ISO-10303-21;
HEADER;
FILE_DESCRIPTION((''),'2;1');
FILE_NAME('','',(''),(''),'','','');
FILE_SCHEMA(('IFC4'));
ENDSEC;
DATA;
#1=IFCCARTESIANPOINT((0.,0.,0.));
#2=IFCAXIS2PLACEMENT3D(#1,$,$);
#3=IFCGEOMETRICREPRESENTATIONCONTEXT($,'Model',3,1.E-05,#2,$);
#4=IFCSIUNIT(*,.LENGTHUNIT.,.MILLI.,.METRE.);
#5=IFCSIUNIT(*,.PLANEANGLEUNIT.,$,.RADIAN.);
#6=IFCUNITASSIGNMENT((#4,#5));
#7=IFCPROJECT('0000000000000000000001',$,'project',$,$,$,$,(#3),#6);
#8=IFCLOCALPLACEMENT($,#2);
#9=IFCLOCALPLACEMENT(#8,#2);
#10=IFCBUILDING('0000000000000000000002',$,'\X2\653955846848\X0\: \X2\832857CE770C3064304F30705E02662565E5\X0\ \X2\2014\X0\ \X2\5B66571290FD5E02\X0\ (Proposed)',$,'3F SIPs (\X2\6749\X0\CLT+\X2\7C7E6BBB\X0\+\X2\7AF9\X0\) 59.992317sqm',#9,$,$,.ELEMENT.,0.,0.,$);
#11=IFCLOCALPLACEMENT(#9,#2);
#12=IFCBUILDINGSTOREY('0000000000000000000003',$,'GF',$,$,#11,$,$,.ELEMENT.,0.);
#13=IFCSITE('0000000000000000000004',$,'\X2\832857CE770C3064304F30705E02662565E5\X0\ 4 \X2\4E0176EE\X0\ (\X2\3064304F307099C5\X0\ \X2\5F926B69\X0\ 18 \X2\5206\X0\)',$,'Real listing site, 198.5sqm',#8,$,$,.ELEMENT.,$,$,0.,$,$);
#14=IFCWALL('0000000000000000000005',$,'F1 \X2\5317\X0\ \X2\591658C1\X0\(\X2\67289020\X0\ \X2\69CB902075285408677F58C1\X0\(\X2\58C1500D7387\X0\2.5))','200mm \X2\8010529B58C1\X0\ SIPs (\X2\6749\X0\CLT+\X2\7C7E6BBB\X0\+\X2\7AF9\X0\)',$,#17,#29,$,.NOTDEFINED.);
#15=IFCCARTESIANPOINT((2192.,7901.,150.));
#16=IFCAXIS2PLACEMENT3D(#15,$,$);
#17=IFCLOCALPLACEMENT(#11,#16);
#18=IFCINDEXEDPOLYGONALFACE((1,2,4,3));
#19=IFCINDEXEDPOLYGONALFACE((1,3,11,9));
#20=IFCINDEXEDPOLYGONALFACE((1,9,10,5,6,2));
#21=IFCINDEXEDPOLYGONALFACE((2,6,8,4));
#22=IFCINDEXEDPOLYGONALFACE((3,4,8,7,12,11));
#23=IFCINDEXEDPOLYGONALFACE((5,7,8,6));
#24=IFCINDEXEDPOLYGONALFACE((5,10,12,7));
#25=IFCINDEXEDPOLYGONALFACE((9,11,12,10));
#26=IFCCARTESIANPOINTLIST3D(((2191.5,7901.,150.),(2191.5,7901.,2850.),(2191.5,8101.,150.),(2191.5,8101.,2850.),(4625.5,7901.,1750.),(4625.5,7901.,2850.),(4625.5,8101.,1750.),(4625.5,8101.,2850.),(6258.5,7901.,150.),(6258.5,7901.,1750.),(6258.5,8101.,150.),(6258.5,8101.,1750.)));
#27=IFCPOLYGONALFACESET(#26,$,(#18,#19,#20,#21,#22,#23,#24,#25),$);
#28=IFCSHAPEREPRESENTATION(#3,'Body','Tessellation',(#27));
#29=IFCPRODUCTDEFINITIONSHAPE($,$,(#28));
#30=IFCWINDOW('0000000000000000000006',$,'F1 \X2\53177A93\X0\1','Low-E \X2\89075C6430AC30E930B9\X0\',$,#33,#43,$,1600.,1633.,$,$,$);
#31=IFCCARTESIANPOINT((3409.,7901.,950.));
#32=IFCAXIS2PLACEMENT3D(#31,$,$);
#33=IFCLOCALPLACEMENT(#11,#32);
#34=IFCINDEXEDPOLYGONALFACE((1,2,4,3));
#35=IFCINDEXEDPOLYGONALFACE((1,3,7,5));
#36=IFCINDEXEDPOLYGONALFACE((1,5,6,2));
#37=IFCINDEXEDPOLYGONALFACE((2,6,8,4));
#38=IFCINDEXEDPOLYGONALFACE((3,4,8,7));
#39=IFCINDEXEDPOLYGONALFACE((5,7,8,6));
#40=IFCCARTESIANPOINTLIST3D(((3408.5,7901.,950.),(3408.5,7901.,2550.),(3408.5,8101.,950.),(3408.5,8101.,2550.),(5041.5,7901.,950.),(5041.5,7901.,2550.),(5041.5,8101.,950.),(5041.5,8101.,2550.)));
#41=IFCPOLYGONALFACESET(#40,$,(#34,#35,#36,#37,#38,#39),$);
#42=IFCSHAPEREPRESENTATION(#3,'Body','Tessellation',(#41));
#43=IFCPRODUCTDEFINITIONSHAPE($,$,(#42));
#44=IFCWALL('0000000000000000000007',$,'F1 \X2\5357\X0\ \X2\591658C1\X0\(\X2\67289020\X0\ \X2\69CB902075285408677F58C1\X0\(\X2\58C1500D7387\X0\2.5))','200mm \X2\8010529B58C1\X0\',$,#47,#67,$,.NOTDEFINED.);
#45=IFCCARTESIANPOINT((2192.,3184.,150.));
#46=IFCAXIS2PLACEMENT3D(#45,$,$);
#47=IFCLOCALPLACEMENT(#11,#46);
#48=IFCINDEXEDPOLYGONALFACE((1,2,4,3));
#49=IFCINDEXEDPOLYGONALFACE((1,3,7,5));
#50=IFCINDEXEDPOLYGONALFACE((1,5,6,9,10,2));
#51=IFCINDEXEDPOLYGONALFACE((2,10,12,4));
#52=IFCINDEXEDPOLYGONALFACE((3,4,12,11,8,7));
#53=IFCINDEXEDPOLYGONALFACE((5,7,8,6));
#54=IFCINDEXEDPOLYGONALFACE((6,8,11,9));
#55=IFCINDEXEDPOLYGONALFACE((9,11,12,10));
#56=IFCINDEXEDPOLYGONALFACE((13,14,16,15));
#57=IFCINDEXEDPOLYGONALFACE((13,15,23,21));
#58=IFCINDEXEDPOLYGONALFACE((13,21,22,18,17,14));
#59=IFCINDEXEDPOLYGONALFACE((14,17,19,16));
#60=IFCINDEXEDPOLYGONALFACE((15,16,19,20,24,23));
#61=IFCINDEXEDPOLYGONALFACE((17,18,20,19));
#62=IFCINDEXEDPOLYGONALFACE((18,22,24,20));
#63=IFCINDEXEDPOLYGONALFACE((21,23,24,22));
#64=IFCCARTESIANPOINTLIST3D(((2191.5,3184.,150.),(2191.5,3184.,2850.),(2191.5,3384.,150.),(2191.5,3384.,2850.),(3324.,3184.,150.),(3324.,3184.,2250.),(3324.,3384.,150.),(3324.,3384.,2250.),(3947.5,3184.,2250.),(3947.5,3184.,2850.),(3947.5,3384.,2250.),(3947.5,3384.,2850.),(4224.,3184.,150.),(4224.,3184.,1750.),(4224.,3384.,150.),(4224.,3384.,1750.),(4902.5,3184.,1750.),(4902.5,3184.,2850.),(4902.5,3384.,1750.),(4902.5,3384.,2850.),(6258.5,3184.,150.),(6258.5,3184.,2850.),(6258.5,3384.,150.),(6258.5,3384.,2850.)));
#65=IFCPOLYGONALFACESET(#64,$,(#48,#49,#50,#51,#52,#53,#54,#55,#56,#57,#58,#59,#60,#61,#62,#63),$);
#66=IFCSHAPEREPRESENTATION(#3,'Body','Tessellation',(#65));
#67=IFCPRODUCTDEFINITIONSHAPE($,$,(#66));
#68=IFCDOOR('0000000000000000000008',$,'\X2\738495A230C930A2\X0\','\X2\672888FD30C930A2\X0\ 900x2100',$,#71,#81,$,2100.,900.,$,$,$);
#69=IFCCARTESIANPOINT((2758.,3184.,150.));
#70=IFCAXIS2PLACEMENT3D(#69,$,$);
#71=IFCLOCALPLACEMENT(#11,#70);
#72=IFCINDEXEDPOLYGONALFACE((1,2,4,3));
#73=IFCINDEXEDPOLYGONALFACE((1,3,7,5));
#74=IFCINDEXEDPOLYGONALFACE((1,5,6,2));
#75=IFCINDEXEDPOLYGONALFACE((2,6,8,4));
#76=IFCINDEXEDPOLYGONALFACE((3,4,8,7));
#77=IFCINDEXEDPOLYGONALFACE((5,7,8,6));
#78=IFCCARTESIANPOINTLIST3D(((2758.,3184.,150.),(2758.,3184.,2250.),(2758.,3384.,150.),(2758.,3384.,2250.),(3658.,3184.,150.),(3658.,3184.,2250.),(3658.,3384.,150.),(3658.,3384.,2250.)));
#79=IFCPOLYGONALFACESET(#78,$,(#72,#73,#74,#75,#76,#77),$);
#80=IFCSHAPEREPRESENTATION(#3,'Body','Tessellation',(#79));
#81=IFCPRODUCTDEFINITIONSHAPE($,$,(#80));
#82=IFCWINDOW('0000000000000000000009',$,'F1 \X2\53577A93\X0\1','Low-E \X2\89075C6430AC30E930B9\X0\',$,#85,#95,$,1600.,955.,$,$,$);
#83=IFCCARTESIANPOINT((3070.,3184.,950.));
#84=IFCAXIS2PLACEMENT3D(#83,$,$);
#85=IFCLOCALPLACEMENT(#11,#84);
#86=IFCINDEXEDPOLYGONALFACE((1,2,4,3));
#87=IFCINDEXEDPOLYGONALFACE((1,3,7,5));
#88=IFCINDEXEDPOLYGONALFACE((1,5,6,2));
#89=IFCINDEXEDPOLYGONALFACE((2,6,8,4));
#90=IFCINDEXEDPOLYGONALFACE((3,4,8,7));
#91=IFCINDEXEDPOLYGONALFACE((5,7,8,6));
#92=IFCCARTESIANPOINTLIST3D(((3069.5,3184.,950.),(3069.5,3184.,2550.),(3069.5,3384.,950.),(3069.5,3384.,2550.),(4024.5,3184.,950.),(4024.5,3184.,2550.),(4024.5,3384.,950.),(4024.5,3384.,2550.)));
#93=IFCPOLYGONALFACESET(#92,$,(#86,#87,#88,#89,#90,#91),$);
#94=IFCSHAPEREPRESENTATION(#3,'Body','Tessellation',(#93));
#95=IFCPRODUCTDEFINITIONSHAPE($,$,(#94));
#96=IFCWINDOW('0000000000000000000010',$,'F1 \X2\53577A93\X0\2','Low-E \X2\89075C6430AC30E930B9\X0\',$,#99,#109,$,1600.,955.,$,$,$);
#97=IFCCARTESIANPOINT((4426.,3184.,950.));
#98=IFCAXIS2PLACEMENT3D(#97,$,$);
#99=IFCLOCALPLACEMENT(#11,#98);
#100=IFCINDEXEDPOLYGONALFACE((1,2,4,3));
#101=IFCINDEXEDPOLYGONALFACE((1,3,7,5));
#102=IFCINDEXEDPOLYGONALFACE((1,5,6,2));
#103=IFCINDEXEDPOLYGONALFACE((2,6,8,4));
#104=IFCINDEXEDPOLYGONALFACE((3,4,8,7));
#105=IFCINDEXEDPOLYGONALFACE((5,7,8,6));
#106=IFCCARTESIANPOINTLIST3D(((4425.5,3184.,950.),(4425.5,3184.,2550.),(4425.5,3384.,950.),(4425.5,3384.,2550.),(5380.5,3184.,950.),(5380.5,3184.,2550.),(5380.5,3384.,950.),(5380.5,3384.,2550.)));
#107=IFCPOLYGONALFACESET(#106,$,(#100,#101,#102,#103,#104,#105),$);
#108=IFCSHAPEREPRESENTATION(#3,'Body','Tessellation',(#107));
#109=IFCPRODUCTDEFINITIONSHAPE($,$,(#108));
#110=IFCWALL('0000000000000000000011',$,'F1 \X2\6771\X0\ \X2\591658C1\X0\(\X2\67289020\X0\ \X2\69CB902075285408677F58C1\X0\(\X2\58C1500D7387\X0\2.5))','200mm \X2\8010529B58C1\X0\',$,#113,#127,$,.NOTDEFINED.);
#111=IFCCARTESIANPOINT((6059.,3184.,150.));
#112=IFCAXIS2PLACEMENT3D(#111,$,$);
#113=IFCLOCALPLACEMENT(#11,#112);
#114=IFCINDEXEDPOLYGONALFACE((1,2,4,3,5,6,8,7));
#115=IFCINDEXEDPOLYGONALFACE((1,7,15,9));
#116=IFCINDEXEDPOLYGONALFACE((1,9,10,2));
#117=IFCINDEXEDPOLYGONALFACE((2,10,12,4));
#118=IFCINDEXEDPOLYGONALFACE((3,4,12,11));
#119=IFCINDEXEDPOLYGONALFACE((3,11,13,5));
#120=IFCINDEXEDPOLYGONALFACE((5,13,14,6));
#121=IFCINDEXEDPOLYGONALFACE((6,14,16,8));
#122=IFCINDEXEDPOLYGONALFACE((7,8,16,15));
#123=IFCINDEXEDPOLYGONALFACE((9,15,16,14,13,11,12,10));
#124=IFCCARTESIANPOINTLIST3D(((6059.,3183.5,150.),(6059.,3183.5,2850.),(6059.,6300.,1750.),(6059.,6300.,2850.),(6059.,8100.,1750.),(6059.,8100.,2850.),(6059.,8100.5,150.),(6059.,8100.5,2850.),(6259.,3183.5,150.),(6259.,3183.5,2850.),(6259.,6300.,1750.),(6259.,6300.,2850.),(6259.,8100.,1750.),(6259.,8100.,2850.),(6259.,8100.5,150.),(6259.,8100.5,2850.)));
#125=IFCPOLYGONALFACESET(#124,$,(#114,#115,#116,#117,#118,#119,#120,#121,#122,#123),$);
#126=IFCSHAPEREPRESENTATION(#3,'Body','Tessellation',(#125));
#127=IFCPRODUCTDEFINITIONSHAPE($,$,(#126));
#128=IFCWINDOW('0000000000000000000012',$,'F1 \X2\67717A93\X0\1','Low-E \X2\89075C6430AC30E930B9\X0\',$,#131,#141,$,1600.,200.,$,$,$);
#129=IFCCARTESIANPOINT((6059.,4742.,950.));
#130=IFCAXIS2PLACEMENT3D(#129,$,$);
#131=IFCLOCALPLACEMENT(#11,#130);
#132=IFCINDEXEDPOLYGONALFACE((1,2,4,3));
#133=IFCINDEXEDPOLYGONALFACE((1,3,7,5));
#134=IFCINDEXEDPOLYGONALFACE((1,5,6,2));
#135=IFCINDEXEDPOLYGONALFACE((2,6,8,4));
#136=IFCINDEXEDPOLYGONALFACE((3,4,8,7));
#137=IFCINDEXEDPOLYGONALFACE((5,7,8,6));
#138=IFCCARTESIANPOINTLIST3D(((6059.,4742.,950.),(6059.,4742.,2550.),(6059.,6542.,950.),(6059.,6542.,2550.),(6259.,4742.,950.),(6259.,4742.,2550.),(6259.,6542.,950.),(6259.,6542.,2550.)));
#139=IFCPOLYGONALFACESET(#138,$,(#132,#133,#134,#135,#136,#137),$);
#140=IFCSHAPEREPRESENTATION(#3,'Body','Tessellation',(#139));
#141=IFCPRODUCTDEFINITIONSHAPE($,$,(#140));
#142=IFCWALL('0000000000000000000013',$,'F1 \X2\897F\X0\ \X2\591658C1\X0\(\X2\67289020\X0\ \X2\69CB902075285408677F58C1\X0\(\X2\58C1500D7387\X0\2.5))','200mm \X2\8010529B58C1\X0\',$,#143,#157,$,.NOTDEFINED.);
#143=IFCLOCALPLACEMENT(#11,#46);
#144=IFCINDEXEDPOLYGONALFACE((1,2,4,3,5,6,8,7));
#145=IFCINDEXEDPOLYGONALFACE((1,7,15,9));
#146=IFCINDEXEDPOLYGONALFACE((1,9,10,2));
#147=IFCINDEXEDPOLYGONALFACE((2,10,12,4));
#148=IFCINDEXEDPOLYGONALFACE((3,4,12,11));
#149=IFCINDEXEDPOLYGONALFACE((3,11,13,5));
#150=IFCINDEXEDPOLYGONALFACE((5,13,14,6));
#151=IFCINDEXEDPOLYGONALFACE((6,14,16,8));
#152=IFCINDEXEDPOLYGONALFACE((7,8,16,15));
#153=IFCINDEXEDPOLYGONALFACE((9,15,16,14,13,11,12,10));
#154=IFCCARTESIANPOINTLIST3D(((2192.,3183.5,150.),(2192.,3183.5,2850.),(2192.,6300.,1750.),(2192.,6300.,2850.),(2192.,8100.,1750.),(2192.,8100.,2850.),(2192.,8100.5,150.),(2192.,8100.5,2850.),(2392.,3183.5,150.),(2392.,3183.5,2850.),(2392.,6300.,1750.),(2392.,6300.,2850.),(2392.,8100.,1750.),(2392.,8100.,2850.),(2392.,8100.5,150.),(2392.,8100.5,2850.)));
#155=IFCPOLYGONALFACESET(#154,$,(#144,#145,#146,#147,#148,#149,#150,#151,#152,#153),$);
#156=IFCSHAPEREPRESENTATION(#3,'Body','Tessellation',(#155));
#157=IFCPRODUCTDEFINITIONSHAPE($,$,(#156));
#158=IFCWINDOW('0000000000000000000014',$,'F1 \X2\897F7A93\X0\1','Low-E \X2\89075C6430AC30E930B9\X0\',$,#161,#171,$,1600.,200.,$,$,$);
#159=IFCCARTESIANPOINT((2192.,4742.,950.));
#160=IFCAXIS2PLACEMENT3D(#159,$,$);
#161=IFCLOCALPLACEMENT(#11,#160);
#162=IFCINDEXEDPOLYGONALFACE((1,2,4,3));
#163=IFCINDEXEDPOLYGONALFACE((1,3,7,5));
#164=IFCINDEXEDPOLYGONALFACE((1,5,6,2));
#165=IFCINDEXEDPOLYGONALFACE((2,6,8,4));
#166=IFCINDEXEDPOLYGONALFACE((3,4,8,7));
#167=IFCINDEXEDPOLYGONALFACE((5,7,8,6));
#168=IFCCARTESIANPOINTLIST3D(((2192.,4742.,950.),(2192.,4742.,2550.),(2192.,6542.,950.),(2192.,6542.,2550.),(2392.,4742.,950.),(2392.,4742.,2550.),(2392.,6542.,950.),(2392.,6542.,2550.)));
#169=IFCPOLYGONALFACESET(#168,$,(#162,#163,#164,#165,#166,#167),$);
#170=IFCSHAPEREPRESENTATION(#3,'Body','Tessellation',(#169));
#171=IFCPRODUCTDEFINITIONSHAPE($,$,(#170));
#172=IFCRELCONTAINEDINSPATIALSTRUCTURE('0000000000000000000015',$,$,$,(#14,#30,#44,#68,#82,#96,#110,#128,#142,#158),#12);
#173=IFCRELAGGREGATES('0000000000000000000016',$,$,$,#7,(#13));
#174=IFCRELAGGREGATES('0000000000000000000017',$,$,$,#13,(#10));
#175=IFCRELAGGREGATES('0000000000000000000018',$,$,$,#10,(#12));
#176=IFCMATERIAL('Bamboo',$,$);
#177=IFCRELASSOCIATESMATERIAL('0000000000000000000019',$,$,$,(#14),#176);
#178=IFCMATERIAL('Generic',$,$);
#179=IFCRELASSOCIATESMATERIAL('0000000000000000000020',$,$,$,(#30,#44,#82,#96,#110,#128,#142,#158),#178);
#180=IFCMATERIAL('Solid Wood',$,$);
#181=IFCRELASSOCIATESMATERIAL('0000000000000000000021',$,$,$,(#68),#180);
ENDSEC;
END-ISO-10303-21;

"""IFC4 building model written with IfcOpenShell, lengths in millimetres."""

from ifc_helpers import new_model, si_unit, frame, frame_2d, origin, place, context, project, spatial, rectangle, extrude, material, element, fill, save


model = new_model("IFC4")

# Units and contexts
model_context = context("Model", 3, precision=1e-05, world=origin())
ifc_project = project(units=[si_unit("LENGTHUNIT", "METRE", prefix="MILLI"), si_unit("PLANEANGLEUNIT", "RADIAN")], contexts=[model_context])

# Site, building, storey
site_placement = place(None, origin())
site = spatial("IfcSite", under=ifc_project, at=site_placement, Name="茨城県つくば市春日 4 丁目 (つくば駅 徒歩 18 分)", ObjectType="Real listing site, 198.5sqm", CompositionType="ELEMENT", RefElevation=0.0)
building_placement = place(site_placement, origin())
building = spatial("IfcBuilding", under=site, at=building_placement, Name="改善案: 茨城県つくば市春日 — 学園都市 (Proposed)", ObjectType="3F SIPs (杉CLT+籾殻+竹) 59.992317sqm", CompositionType="ELEMENT", ElevationOfRefHeight=0.0, ElevationOfTerrain=0.0)
storey_placement = place(building_placement, origin())
storey = spatial("IfcBuildingStorey", under=building, at=storey_placement, Name="GF", CompositionType="ELEMENT", Elevation=0.0)

# Shared definitions
ifc_material_1 = material(Name="Generic")

# Wall, opening, window
ifc_material_2 = material(Name="Bamboo")
wall_1_placement = place(storey_placement, frame((2192.0, 7901.0, 150.0)))
wall_1 = element("IfcWall", 1, at=wall_1_placement, inside=storey, material=ifc_material_2, Name="F1 北 外壁(木造 構造用合板壁(壁倍率2.5))", Description="200mm 耐力壁 SIPs (杉CLT+籾殻+竹)", PredefinedType="NOTDEFINED", context=model_context, shape_type="SweptSolid", body=[
    extrude(rectangle(XDim=4067.0, YDim=200.0, at=frame_2d((2033.0, 100.0))), frame((2192.0, 7901.0, 150.0)), (0.0, 0.0, 1.0), 2700.0),
])
opening_1_placement = place(storey_placement, frame((3409.0, 7901.0, 950.0)))
opening_1 = element("IfcOpeningElement", 2, at=opening_1_placement, cuts=wall_1, PredefinedType="NOTDEFINED", context=model_context, shape_type="SweptSolid", body=[
    extrude(rectangle(XDim=1633.0, YDim=200.0, at=frame_2d((816.0, 100.0))), frame((3409.0, 7901.0, 950.0)), (0.0, 0.0, 1.0), 1600.0),
])
window_1_placement = place(storey_placement, frame((3409.0, 7901.0, 950.0)))
window_1 = element("IfcWindow", 3, at=window_1_placement, inside=storey, material=ifc_material_1, Name="F1 北窓1", Description="Low-E 複層ガラス", OverallHeight=1600.0, OverallWidth=1633.0, context=model_context, shape_type="SweptSolid", body=[
    extrude(rectangle(XDim=1633.0, YDim=200.0, at=frame_2d((816.0, 100.0))), frame((3409.0, 7901.0, 950.0)), (0.0, 0.0, 1.0), 1600.0),
])
fill(opening_1, window_1)

# Wall, openings, door, windows
wall_2_placement = place(storey_placement, frame((2192.0, 3184.0, 150.0)))
wall_2 = element("IfcWall", 4, at=wall_2_placement, inside=storey, material=ifc_material_1, Name="F1 南 外壁(木造 構造用合板壁(壁倍率2.5))", Description="200mm 耐力壁", PredefinedType="NOTDEFINED", context=model_context, shape_type="SweptSolid", body=[
    extrude(rectangle(XDim=4067.0, YDim=200.0, at=frame_2d((2033.0, 100.0))), frame((2192.0, 3184.0, 150.0)), (0.0, 0.0, 1.0), 2700.0),
])
opening_2_placement = place(storey_placement, frame((2758.0, 3184.0, 150.0)))
opening_2 = element("IfcOpeningElement", 5, at=opening_2_placement, cuts=wall_2, PredefinedType="NOTDEFINED", context=model_context, shape_type="SweptSolid", body=[
    extrude(rectangle(XDim=900.0, YDim=200.0, at=frame_2d((450.0, 100.0))), frame((2758.0, 3184.0, 150.0)), (0.0, 0.0, 1.0), 2100.0),
])
opening_3_placement = place(storey_placement, frame((3070.0, 3184.0, 950.0)))
opening_3 = element("IfcOpeningElement", 6, at=opening_3_placement, cuts=wall_2, PredefinedType="NOTDEFINED", context=model_context, shape_type="SweptSolid", body=[
    extrude(rectangle(XDim=955.0, YDim=200.0, at=frame_2d((477.0, 100.0))), frame((3070.0, 3184.0, 950.0)), (0.0, 0.0, 1.0), 1600.0),
])
opening_4_placement = place(storey_placement, frame((4426.0, 3184.0, 950.0)))
opening_4 = element("IfcOpeningElement", 7, at=opening_4_placement, cuts=wall_2, PredefinedType="NOTDEFINED", context=model_context, shape_type="SweptSolid", body=[
    extrude(rectangle(XDim=955.0, YDim=200.0, at=frame_2d((477.0, 100.0))), frame((4426.0, 3184.0, 950.0)), (0.0, 0.0, 1.0), 1600.0),
])
ifc_material_3 = material(Name="Solid Wood")
door_placement = place(storey_placement, frame((2758.0, 3184.0, 150.0)))
door = element("IfcDoor", 8, at=door_placement, inside=storey, material=ifc_material_3, Name="玄関ドア", Description="木製ドア 900x2100", OverallHeight=2100.0, OverallWidth=900.0, context=model_context, shape_type="SweptSolid", body=[
    extrude(rectangle(XDim=900.0, YDim=200.0, at=frame_2d((450.0, 100.0))), frame((2758.0, 3184.0, 150.0)), (0.0, 0.0, 1.0), 2100.0),
])
fill(opening_2, door)
window_2_placement = place(storey_placement, frame((3070.0, 3184.0, 950.0)))
window_2 = element("IfcWindow", 9, at=window_2_placement, inside=storey, material=ifc_material_1, Name="F1 南窓1", Description="Low-E 複層ガラス", OverallHeight=1600.0, OverallWidth=955.0, context=model_context, shape_type="SweptSolid", body=[
    extrude(rectangle(XDim=955.0, YDim=200.0, at=frame_2d((477.0, 100.0))), frame((3070.0, 3184.0, 950.0)), (0.0, 0.0, 1.0), 1600.0),
])
fill(opening_3, window_2)
window_3_placement = place(storey_placement, frame((4426.0, 3184.0, 950.0)))
window_3 = element("IfcWindow", 10, at=window_3_placement, inside=storey, material=ifc_material_1, Name="F1 南窓2", Description="Low-E 複層ガラス", OverallHeight=1600.0, OverallWidth=955.0, context=model_context, shape_type="SweptSolid", body=[
    extrude(rectangle(XDim=955.0, YDim=200.0, at=frame_2d((477.0, 100.0))), frame((4426.0, 3184.0, 950.0)), (0.0, 0.0, 1.0), 1600.0),
])
fill(opening_4, window_3)

# Walls, openings, windows
wall_3_placement = place(storey_placement, frame((6059.0, 3184.0, 150.0)))
wall_3 = element("IfcWall", 11, at=wall_3_placement, inside=storey, material=ifc_material_1, Name="F1 東 外壁(木造 構造用合板壁(壁倍率2.5))", Description="200mm 耐力壁", PredefinedType="NOTDEFINED", context=model_context, shape_type="SweptSolid", body=[
    extrude(rectangle(XDim=200.0, YDim=4917.0, at=frame_2d((100.0, 2458.0))), frame((6059.0, 3184.0, 150.0)), (0.0, 0.0, 1.0), 2700.0),
])
opening_5_placement = place(storey_placement, frame((6059.0, 4742.0, 950.0)))
opening_5 = element("IfcOpeningElement", 12, at=opening_5_placement, cuts=wall_3, PredefinedType="NOTDEFINED", context=model_context, shape_type="SweptSolid", body=[
    extrude(rectangle(XDim=200.0, YDim=1800.0, at=frame_2d((100.0, 900.0))), frame((6059.0, 4742.0, 950.0)), (0.0, 0.0, 1.0), 1600.0),
])
window_4_placement = place(storey_placement, frame((6059.0, 4742.0, 950.0)))
window_4 = element("IfcWindow", 13, at=window_4_placement, inside=storey, material=ifc_material_1, Name="F1 東窓1", Description="Low-E 複層ガラス", OverallHeight=1600.0, OverallWidth=200.0, context=model_context, shape_type="SweptSolid", body=[
    extrude(rectangle(XDim=200.0, YDim=1800.0, at=frame_2d((100.0, 900.0))), frame((6059.0, 4742.0, 950.0)), (0.0, 0.0, 1.0), 1600.0),
])
fill(opening_5, window_4)
wall_4_placement = place(storey_placement, frame((2192.0, 3184.0, 150.0)))
wall_4 = element("IfcWall", 14, at=wall_4_placement, inside=storey, material=ifc_material_1, Name="F1 西 外壁(木造 構造用合板壁(壁倍率2.5))", Description="200mm 耐力壁", PredefinedType="NOTDEFINED", context=model_context, shape_type="SweptSolid", body=[
    extrude(rectangle(XDim=200.0, YDim=4917.0, at=frame_2d((100.0, 2458.0))), frame((2192.0, 3184.0, 150.0)), (0.0, 0.0, 1.0), 2700.0),
])
opening_6_placement = place(storey_placement, frame((2192.0, 4742.0, 950.0)))
opening_6 = element("IfcOpeningElement", 15, at=opening_6_placement, cuts=wall_4, PredefinedType="NOTDEFINED", context=model_context, shape_type="SweptSolid", body=[
    extrude(rectangle(XDim=200.0, YDim=1800.0, at=frame_2d((100.0, 900.0))), frame((2192.0, 4742.0, 950.0)), (0.0, 0.0, 1.0), 1600.0),
])
window_5_placement = place(storey_placement, frame((2192.0, 4742.0, 950.0)))
window_5 = element("IfcWindow", 16, at=window_5_placement, inside=storey, material=ifc_material_1, Name="F1 西窓1", Description="Low-E 複層ガラス", OverallHeight=1600.0, OverallWidth=200.0, context=model_context, shape_type="SweptSolid", body=[
    extrude(rectangle(XDim=200.0, YDim=1800.0, at=frame_2d((100.0, 900.0))), frame((2192.0, 4742.0, 950.0)), (0.0, 0.0, 1.0), 1600.0),
])
fill(opening_6, window_5)

save(model, "model.ifc")
